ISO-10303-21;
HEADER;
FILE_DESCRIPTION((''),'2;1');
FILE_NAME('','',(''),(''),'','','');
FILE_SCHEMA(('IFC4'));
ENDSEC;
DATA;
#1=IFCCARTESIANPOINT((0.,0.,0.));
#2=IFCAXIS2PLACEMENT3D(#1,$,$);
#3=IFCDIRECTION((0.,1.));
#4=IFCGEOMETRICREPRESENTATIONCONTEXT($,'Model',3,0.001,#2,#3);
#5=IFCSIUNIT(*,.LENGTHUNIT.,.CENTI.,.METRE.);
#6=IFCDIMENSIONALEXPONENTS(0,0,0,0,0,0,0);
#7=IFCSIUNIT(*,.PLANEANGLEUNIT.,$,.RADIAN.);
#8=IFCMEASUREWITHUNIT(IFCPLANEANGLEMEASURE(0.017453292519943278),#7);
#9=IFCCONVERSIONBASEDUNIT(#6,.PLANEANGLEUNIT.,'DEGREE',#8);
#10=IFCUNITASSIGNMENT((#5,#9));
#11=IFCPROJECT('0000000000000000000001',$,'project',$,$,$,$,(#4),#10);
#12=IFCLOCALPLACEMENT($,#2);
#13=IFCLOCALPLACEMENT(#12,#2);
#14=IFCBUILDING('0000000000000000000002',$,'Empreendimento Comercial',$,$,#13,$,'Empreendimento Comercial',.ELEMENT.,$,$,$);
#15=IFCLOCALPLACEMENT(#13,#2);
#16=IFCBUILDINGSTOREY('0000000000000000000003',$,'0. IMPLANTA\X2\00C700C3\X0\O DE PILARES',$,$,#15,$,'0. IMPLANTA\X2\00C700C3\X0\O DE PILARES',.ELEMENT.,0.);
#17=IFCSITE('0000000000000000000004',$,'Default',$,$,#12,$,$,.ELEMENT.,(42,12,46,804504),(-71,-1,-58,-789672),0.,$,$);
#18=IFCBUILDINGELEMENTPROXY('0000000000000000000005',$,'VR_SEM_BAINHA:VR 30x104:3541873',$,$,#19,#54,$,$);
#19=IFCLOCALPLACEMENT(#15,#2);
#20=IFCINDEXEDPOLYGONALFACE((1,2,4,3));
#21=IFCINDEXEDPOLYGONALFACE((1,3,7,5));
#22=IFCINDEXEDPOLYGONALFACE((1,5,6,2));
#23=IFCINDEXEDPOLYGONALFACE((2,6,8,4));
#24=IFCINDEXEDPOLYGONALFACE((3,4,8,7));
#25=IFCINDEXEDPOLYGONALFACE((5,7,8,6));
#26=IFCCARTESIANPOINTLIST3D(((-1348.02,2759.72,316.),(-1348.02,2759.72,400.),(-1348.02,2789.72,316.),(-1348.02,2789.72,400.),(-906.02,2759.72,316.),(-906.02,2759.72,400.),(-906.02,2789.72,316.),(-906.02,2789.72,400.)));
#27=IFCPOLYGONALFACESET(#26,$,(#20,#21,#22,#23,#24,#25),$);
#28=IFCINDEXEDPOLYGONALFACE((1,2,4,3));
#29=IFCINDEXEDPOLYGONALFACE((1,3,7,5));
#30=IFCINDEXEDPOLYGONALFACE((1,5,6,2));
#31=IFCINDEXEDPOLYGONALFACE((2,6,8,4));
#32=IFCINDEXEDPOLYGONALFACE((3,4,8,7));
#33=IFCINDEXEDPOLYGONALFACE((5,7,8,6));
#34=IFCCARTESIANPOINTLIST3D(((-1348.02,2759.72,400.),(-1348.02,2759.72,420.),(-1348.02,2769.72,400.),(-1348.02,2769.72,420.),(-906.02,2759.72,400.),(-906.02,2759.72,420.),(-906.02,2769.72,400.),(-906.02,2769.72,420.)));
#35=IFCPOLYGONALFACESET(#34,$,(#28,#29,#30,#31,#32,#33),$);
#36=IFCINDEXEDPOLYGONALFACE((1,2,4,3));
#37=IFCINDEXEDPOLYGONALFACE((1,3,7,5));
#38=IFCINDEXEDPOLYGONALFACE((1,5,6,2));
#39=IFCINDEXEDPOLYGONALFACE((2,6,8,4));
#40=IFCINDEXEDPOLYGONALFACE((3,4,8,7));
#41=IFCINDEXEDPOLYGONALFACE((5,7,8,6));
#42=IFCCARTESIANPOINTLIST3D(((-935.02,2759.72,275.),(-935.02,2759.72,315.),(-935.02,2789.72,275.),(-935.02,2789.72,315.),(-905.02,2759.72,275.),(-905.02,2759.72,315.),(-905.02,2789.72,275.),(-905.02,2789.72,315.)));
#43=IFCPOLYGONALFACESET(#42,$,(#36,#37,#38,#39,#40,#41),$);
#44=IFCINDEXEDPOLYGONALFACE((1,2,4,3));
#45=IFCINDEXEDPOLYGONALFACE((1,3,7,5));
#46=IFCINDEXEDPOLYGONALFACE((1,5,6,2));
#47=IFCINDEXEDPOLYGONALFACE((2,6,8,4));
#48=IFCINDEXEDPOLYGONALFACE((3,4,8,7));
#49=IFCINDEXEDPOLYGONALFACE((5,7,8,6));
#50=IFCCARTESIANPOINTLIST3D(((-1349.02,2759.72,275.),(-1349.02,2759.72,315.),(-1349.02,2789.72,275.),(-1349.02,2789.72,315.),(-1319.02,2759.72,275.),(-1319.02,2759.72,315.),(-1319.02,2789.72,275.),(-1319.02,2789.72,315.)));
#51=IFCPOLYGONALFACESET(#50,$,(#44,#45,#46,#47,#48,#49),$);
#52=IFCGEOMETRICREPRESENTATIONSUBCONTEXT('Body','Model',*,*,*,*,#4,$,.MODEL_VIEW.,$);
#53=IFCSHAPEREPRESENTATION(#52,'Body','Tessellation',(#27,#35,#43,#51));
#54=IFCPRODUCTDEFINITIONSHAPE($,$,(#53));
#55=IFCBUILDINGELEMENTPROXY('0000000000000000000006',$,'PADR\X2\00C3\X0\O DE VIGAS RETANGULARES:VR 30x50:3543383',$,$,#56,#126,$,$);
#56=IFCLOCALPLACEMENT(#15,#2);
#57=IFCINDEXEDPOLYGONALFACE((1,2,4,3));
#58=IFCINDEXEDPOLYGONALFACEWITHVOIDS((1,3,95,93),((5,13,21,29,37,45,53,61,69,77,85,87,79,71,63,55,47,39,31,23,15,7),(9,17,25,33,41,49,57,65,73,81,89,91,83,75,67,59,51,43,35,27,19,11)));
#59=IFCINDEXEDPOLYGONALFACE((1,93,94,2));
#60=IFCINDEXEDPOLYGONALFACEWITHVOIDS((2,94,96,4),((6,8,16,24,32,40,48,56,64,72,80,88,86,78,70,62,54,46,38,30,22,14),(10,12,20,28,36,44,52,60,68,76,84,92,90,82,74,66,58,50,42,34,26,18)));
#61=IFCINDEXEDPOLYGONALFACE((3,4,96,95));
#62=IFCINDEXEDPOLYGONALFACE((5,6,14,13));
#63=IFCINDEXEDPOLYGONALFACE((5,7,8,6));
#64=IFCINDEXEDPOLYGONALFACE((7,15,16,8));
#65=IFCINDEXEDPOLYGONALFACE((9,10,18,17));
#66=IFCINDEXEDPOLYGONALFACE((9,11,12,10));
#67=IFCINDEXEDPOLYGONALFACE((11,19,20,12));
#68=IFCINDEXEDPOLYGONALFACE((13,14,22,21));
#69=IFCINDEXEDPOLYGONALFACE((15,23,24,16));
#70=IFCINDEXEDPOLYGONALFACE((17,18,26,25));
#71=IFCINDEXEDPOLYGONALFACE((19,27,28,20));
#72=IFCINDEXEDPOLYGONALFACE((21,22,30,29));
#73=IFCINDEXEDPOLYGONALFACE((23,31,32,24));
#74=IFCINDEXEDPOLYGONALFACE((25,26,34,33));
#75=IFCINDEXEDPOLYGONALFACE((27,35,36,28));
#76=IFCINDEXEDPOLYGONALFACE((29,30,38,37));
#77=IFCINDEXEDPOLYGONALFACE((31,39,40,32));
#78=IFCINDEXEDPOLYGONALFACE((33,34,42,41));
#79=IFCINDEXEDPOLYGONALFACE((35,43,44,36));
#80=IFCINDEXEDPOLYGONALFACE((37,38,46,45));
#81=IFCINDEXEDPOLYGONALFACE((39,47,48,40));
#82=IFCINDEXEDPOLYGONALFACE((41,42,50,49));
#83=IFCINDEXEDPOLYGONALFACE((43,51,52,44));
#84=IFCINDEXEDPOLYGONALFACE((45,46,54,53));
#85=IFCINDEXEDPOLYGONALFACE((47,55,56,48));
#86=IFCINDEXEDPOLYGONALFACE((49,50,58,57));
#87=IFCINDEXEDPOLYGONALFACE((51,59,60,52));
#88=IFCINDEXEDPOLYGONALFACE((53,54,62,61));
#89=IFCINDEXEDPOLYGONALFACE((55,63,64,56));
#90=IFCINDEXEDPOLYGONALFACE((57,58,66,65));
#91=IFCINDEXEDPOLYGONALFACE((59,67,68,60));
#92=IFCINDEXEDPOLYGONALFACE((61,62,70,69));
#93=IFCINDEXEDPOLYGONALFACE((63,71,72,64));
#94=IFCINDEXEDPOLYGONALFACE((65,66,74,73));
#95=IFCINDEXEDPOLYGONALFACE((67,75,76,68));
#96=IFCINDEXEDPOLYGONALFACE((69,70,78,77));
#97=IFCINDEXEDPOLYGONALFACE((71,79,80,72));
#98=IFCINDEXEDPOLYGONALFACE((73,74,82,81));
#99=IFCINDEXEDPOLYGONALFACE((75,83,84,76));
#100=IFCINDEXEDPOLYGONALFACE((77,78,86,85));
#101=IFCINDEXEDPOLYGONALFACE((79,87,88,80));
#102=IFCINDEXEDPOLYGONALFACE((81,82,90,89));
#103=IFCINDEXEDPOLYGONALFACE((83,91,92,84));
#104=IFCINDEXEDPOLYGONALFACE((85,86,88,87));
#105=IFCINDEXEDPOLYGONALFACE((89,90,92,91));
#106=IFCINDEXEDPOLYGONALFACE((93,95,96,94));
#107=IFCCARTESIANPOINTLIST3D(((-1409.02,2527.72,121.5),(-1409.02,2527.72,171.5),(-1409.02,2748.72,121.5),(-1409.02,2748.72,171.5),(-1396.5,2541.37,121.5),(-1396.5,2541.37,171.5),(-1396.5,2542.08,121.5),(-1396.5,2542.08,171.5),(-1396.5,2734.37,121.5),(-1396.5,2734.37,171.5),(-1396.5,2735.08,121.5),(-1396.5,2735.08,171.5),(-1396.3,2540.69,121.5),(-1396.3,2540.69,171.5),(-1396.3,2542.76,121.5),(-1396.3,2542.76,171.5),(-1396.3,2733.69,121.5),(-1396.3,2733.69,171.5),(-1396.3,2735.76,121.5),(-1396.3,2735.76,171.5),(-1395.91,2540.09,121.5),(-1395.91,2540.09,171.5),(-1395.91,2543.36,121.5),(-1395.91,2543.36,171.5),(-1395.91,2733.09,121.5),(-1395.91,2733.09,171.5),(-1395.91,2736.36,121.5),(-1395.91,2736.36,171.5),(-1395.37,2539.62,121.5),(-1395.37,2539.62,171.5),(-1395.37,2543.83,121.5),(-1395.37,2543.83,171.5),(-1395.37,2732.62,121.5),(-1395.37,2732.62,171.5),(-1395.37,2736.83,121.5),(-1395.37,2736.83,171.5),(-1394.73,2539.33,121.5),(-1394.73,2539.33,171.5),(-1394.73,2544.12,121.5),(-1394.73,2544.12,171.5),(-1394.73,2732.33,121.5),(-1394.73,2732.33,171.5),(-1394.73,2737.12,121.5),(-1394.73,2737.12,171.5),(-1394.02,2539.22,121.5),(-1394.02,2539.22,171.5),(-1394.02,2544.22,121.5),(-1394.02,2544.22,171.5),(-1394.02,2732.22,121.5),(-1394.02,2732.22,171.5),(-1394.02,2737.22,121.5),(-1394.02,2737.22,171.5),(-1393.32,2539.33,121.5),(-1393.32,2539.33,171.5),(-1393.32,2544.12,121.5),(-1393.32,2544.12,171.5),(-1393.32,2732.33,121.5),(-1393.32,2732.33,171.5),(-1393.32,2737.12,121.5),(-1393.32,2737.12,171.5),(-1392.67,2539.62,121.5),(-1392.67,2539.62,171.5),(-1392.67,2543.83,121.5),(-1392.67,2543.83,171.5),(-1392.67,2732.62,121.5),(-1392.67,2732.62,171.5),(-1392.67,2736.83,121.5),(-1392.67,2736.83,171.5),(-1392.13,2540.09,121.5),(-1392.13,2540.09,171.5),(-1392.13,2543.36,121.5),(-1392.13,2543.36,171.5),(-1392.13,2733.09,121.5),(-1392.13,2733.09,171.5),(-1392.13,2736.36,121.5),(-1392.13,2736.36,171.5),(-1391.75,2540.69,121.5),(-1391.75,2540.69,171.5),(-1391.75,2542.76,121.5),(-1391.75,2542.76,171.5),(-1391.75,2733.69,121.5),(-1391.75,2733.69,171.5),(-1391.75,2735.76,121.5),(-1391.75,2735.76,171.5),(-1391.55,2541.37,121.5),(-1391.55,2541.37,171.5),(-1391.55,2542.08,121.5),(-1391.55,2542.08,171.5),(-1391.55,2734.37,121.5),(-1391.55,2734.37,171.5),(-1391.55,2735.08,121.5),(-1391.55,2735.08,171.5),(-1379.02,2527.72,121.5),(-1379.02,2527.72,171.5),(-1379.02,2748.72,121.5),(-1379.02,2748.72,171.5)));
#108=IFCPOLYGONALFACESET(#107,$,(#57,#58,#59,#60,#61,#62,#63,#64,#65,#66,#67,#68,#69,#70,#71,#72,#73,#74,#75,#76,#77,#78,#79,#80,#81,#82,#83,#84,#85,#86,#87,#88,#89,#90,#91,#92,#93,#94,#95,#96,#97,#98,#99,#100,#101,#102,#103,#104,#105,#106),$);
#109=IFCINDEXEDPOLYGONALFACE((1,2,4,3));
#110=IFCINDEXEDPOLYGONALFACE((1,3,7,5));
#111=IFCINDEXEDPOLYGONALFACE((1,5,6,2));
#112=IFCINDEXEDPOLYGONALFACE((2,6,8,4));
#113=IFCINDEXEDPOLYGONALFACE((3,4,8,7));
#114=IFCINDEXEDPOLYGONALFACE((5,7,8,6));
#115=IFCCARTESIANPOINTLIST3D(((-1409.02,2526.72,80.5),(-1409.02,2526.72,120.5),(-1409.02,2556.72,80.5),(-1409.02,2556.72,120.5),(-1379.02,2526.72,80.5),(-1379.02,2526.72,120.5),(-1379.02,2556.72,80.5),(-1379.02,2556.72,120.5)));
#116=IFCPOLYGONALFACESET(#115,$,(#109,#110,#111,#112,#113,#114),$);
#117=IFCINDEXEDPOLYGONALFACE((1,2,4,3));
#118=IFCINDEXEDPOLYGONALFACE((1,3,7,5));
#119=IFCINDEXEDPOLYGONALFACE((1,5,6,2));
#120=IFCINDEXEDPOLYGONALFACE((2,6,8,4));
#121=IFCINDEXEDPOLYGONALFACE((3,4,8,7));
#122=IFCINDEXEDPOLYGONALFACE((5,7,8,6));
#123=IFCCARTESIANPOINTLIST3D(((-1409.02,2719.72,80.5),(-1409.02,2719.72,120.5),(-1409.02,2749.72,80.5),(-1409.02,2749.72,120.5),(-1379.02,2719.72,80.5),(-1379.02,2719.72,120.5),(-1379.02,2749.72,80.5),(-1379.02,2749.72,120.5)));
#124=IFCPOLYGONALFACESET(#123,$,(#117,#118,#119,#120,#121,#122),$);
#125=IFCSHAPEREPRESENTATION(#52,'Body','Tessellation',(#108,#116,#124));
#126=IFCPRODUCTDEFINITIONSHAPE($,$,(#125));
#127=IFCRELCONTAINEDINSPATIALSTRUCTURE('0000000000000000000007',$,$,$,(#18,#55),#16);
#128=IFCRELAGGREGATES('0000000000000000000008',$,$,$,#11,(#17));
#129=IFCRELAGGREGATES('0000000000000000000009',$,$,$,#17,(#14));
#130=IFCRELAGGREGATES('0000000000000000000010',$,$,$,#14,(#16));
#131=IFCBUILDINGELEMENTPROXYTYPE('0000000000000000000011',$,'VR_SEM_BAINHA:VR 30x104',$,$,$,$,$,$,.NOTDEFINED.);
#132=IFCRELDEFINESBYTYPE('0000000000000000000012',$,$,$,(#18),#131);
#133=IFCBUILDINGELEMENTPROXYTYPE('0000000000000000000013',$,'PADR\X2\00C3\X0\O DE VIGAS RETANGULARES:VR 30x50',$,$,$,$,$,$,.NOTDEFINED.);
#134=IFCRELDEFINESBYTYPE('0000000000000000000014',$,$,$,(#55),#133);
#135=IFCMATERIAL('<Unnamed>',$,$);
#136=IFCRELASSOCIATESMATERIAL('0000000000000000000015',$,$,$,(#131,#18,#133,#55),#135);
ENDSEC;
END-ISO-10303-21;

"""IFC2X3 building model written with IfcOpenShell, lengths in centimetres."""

from ifc_helpers import new_model, entity, si_unit, converted_unit, direction, frame, frame_2d, origin, origin_2d_with_axis, place, context, subcontext, project, spatial, polyline, circle_curve, parameter, trimmed, segment, composite_curve, rectangle, outline, extrude, source, transform, mapped, material, type_object, type_shapes, element, save


model = new_model("IFC2X3")

# Units and contexts
model_context = context("Model", 3, precision=0.001, world=origin(), true_north=direction((0.0, 1.0)))
body_context = subcontext(model_context, "Body", "Model", "MODEL_VIEW")
ifc_project = project(units=[si_unit("LENGTHUNIT", "METRE", prefix="CENTI"), converted_unit("PLANEANGLEUNIT", "DEGREE", entity("IfcPlaneAngleMeasure", 0.017453292519943278), si_unit("PLANEANGLEUNIT", "RADIAN"), dimensions=[0, 0, 0, 0, 0, 0, 0])], contexts=[model_context])

# Site, building, storey
site_placement = place(None, origin())
site = spatial("IfcSite", under=ifc_project, at=site_placement, Name="Default", CompositionType="ELEMENT", RefLatitude=(42, 12, 46, 804504), RefLongitude=(-71, -1, -58, -789672), RefElevation=0.0)
building_placement = place(site_placement, origin())
building = spatial("IfcBuilding", under=site, at=building_placement, Name="Empreendimento Comercial", LongName="Empreendimento Comercial", CompositionType="ELEMENT")
storey_placement = place(building_placement, origin())
storey = spatial("IfcBuildingStorey", under=building, at=storey_placement, Name="0. IMPLANTAÇÃO DE PILARES", LongName="0. IMPLANTAÇÃO DE PILARES", CompositionType="ELEMENT", Elevation=0.0)

# Shared definitions
ifc_material_1 = material(Name="<Unnamed>")

# Building element proxies
building_element_proxy_type_1 = type_object("IfcBuildingElementProxyType", Name="VR_SEM_BAINHA:VR 30x104", PredefinedType="NOTDEFINED", material=ifc_material_1)
shared_shape_1 = source(origin(), body_context, "Body", "SweptSolid", [
    extrude(rectangle(XDim=442.0, YDim=30.0, at=frame_2d((0.0, 0.0), x_axis=(1.0, 0.0))), frame((-1127.02, 2774.72, 316.0)), (0.0, 0.0, 1.0), 84.0),
    extrude(rectangle(XDim=442.0, YDim=10.0, at=frame_2d((0.0, 0.0), x_axis=(1.0, 0.0))), frame((-1127.02, 2764.72, 400.0)), (0.0, 0.0, 1.0), 20.0),
    extrude(rectangle(XDim=30.0, YDim=30.0, at=origin_2d_with_axis()), frame((-920.02, 2774.72, 275.0), z_axis=(0.0, 0.0, 1.0), x_axis=(0.0, -1.0, 0.0)), (0.0, 0.0, 1.0), 40.0),
    extrude(rectangle(XDim=30.0, YDim=30.0, at=frame_2d((0.0, 0.0), x_axis=(1.0, 0.0))), frame((-1334.02, 2774.72, 275.0), z_axis=(0.0, 0.0, 1.0), x_axis=(0.0, -1.0, 0.0)), (0.0, 0.0, 1.0), 40.0),
])
type_shapes(building_element_proxy_type_1, [shared_shape_1])
proxy_1_placement = place(storey_placement, origin())
element("IfcBuildingElementProxy", 1, at=proxy_1_placement, inside=storey, type_object=building_element_proxy_type_1, material=ifc_material_1, Name="VR_SEM_BAINHA:VR 30x104:3541873", context=body_context, shape_type="MappedRepresentation", body=[
    mapped(shared_shape_1, transform((0.0, 0.0, 0.0), scale=1.0)),
])
building_element_proxy_type_2 = type_object("IfcBuildingElementProxyType", Name="PADRÃO DE VIGAS RETANGULARES:VR 30x50", PredefinedType="NOTDEFINED", material=ifc_material_1)
shared_shape_2 = source(origin(), body_context, "Body", "SweptSolid", [
    extrude(outline(polyline([(-110.5, -15.0), (110.5, -15.0), (110.5, 15.0), (-110.5, 15.0), (-110.5, -15.0)]), holes=[composite_curve([segment(trimmed(circle_curve(frame_2d((96.5, 0.0), x_axis=(-1.0, 0.0)), 2.5), [parameter(0.0)], [parameter(180.0)], True, "PARAMETER"), False, "CONTINUOUS"), segment(trimmed(circle_curve(frame_2d((96.5, 0.0), x_axis=(-1.0, 0.0)), 2.5), [parameter(180.0)], [parameter(0.0)], True, "PARAMETER"), False, "CONTINUOUS")], self_intersect=False), composite_curve([segment(trimmed(circle_curve(frame_2d((-96.5, 0.0), x_axis=(-1.0, 0.0)), 2.5), [parameter(0.0)], [parameter(180.0)], True, "PARAMETER"), False, "CONTINUOUS"), segment(trimmed(circle_curve(frame_2d((-96.5, 0.0), x_axis=(-1.0, 0.0)), 2.5), [parameter(180.0)], [parameter(0.0)], True, "PARAMETER"), False, "CONTINUOUS")], self_intersect=False)]), frame((-1394.02, 2638.22, 121.5), z_axis=(0.0, 0.0, 1.0), x_axis=(0.0, -1.0, 0.0)), (0.0, 0.0, 1.0), 50.0),
    extrude(rectangle(XDim=30.0, YDim=30.0, at=frame_2d((0.0, 0.0), x_axis=(1.0, 0.0))), frame((-1394.02, 2541.72, 80.5), z_axis=(0.0, 0.0, 1.0), x_axis=(-1.0, 0.0, 0.0)), (0.0, 0.0, 1.0), 40.0),
    extrude(rectangle(XDim=30.0, YDim=30.0, at=frame_2d((0.0, 0.0), x_axis=(1.0, 0.0))), frame((-1394.02, 2734.72, 80.5), z_axis=(0.0, 0.0, 1.0), x_axis=(-1.0, 0.0, 0.0)), (0.0, 0.0, 1.0), 40.0),
])
type_shapes(building_element_proxy_type_2, [shared_shape_2])
proxy_2_placement = place(storey_placement, origin())
element("IfcBuildingElementProxy", 2, at=proxy_2_placement, inside=storey, type_object=building_element_proxy_type_2, material=ifc_material_1, Name="PADRÃO DE VIGAS RETANGULARES:VR 30x50:3543383", context=body_context, shape_type="MappedRepresentation", body=[
    mapped(shared_shape_2, transform((0.0, 0.0, 0.0), scale=1.0)),
])

save(model, "model.ifc")
